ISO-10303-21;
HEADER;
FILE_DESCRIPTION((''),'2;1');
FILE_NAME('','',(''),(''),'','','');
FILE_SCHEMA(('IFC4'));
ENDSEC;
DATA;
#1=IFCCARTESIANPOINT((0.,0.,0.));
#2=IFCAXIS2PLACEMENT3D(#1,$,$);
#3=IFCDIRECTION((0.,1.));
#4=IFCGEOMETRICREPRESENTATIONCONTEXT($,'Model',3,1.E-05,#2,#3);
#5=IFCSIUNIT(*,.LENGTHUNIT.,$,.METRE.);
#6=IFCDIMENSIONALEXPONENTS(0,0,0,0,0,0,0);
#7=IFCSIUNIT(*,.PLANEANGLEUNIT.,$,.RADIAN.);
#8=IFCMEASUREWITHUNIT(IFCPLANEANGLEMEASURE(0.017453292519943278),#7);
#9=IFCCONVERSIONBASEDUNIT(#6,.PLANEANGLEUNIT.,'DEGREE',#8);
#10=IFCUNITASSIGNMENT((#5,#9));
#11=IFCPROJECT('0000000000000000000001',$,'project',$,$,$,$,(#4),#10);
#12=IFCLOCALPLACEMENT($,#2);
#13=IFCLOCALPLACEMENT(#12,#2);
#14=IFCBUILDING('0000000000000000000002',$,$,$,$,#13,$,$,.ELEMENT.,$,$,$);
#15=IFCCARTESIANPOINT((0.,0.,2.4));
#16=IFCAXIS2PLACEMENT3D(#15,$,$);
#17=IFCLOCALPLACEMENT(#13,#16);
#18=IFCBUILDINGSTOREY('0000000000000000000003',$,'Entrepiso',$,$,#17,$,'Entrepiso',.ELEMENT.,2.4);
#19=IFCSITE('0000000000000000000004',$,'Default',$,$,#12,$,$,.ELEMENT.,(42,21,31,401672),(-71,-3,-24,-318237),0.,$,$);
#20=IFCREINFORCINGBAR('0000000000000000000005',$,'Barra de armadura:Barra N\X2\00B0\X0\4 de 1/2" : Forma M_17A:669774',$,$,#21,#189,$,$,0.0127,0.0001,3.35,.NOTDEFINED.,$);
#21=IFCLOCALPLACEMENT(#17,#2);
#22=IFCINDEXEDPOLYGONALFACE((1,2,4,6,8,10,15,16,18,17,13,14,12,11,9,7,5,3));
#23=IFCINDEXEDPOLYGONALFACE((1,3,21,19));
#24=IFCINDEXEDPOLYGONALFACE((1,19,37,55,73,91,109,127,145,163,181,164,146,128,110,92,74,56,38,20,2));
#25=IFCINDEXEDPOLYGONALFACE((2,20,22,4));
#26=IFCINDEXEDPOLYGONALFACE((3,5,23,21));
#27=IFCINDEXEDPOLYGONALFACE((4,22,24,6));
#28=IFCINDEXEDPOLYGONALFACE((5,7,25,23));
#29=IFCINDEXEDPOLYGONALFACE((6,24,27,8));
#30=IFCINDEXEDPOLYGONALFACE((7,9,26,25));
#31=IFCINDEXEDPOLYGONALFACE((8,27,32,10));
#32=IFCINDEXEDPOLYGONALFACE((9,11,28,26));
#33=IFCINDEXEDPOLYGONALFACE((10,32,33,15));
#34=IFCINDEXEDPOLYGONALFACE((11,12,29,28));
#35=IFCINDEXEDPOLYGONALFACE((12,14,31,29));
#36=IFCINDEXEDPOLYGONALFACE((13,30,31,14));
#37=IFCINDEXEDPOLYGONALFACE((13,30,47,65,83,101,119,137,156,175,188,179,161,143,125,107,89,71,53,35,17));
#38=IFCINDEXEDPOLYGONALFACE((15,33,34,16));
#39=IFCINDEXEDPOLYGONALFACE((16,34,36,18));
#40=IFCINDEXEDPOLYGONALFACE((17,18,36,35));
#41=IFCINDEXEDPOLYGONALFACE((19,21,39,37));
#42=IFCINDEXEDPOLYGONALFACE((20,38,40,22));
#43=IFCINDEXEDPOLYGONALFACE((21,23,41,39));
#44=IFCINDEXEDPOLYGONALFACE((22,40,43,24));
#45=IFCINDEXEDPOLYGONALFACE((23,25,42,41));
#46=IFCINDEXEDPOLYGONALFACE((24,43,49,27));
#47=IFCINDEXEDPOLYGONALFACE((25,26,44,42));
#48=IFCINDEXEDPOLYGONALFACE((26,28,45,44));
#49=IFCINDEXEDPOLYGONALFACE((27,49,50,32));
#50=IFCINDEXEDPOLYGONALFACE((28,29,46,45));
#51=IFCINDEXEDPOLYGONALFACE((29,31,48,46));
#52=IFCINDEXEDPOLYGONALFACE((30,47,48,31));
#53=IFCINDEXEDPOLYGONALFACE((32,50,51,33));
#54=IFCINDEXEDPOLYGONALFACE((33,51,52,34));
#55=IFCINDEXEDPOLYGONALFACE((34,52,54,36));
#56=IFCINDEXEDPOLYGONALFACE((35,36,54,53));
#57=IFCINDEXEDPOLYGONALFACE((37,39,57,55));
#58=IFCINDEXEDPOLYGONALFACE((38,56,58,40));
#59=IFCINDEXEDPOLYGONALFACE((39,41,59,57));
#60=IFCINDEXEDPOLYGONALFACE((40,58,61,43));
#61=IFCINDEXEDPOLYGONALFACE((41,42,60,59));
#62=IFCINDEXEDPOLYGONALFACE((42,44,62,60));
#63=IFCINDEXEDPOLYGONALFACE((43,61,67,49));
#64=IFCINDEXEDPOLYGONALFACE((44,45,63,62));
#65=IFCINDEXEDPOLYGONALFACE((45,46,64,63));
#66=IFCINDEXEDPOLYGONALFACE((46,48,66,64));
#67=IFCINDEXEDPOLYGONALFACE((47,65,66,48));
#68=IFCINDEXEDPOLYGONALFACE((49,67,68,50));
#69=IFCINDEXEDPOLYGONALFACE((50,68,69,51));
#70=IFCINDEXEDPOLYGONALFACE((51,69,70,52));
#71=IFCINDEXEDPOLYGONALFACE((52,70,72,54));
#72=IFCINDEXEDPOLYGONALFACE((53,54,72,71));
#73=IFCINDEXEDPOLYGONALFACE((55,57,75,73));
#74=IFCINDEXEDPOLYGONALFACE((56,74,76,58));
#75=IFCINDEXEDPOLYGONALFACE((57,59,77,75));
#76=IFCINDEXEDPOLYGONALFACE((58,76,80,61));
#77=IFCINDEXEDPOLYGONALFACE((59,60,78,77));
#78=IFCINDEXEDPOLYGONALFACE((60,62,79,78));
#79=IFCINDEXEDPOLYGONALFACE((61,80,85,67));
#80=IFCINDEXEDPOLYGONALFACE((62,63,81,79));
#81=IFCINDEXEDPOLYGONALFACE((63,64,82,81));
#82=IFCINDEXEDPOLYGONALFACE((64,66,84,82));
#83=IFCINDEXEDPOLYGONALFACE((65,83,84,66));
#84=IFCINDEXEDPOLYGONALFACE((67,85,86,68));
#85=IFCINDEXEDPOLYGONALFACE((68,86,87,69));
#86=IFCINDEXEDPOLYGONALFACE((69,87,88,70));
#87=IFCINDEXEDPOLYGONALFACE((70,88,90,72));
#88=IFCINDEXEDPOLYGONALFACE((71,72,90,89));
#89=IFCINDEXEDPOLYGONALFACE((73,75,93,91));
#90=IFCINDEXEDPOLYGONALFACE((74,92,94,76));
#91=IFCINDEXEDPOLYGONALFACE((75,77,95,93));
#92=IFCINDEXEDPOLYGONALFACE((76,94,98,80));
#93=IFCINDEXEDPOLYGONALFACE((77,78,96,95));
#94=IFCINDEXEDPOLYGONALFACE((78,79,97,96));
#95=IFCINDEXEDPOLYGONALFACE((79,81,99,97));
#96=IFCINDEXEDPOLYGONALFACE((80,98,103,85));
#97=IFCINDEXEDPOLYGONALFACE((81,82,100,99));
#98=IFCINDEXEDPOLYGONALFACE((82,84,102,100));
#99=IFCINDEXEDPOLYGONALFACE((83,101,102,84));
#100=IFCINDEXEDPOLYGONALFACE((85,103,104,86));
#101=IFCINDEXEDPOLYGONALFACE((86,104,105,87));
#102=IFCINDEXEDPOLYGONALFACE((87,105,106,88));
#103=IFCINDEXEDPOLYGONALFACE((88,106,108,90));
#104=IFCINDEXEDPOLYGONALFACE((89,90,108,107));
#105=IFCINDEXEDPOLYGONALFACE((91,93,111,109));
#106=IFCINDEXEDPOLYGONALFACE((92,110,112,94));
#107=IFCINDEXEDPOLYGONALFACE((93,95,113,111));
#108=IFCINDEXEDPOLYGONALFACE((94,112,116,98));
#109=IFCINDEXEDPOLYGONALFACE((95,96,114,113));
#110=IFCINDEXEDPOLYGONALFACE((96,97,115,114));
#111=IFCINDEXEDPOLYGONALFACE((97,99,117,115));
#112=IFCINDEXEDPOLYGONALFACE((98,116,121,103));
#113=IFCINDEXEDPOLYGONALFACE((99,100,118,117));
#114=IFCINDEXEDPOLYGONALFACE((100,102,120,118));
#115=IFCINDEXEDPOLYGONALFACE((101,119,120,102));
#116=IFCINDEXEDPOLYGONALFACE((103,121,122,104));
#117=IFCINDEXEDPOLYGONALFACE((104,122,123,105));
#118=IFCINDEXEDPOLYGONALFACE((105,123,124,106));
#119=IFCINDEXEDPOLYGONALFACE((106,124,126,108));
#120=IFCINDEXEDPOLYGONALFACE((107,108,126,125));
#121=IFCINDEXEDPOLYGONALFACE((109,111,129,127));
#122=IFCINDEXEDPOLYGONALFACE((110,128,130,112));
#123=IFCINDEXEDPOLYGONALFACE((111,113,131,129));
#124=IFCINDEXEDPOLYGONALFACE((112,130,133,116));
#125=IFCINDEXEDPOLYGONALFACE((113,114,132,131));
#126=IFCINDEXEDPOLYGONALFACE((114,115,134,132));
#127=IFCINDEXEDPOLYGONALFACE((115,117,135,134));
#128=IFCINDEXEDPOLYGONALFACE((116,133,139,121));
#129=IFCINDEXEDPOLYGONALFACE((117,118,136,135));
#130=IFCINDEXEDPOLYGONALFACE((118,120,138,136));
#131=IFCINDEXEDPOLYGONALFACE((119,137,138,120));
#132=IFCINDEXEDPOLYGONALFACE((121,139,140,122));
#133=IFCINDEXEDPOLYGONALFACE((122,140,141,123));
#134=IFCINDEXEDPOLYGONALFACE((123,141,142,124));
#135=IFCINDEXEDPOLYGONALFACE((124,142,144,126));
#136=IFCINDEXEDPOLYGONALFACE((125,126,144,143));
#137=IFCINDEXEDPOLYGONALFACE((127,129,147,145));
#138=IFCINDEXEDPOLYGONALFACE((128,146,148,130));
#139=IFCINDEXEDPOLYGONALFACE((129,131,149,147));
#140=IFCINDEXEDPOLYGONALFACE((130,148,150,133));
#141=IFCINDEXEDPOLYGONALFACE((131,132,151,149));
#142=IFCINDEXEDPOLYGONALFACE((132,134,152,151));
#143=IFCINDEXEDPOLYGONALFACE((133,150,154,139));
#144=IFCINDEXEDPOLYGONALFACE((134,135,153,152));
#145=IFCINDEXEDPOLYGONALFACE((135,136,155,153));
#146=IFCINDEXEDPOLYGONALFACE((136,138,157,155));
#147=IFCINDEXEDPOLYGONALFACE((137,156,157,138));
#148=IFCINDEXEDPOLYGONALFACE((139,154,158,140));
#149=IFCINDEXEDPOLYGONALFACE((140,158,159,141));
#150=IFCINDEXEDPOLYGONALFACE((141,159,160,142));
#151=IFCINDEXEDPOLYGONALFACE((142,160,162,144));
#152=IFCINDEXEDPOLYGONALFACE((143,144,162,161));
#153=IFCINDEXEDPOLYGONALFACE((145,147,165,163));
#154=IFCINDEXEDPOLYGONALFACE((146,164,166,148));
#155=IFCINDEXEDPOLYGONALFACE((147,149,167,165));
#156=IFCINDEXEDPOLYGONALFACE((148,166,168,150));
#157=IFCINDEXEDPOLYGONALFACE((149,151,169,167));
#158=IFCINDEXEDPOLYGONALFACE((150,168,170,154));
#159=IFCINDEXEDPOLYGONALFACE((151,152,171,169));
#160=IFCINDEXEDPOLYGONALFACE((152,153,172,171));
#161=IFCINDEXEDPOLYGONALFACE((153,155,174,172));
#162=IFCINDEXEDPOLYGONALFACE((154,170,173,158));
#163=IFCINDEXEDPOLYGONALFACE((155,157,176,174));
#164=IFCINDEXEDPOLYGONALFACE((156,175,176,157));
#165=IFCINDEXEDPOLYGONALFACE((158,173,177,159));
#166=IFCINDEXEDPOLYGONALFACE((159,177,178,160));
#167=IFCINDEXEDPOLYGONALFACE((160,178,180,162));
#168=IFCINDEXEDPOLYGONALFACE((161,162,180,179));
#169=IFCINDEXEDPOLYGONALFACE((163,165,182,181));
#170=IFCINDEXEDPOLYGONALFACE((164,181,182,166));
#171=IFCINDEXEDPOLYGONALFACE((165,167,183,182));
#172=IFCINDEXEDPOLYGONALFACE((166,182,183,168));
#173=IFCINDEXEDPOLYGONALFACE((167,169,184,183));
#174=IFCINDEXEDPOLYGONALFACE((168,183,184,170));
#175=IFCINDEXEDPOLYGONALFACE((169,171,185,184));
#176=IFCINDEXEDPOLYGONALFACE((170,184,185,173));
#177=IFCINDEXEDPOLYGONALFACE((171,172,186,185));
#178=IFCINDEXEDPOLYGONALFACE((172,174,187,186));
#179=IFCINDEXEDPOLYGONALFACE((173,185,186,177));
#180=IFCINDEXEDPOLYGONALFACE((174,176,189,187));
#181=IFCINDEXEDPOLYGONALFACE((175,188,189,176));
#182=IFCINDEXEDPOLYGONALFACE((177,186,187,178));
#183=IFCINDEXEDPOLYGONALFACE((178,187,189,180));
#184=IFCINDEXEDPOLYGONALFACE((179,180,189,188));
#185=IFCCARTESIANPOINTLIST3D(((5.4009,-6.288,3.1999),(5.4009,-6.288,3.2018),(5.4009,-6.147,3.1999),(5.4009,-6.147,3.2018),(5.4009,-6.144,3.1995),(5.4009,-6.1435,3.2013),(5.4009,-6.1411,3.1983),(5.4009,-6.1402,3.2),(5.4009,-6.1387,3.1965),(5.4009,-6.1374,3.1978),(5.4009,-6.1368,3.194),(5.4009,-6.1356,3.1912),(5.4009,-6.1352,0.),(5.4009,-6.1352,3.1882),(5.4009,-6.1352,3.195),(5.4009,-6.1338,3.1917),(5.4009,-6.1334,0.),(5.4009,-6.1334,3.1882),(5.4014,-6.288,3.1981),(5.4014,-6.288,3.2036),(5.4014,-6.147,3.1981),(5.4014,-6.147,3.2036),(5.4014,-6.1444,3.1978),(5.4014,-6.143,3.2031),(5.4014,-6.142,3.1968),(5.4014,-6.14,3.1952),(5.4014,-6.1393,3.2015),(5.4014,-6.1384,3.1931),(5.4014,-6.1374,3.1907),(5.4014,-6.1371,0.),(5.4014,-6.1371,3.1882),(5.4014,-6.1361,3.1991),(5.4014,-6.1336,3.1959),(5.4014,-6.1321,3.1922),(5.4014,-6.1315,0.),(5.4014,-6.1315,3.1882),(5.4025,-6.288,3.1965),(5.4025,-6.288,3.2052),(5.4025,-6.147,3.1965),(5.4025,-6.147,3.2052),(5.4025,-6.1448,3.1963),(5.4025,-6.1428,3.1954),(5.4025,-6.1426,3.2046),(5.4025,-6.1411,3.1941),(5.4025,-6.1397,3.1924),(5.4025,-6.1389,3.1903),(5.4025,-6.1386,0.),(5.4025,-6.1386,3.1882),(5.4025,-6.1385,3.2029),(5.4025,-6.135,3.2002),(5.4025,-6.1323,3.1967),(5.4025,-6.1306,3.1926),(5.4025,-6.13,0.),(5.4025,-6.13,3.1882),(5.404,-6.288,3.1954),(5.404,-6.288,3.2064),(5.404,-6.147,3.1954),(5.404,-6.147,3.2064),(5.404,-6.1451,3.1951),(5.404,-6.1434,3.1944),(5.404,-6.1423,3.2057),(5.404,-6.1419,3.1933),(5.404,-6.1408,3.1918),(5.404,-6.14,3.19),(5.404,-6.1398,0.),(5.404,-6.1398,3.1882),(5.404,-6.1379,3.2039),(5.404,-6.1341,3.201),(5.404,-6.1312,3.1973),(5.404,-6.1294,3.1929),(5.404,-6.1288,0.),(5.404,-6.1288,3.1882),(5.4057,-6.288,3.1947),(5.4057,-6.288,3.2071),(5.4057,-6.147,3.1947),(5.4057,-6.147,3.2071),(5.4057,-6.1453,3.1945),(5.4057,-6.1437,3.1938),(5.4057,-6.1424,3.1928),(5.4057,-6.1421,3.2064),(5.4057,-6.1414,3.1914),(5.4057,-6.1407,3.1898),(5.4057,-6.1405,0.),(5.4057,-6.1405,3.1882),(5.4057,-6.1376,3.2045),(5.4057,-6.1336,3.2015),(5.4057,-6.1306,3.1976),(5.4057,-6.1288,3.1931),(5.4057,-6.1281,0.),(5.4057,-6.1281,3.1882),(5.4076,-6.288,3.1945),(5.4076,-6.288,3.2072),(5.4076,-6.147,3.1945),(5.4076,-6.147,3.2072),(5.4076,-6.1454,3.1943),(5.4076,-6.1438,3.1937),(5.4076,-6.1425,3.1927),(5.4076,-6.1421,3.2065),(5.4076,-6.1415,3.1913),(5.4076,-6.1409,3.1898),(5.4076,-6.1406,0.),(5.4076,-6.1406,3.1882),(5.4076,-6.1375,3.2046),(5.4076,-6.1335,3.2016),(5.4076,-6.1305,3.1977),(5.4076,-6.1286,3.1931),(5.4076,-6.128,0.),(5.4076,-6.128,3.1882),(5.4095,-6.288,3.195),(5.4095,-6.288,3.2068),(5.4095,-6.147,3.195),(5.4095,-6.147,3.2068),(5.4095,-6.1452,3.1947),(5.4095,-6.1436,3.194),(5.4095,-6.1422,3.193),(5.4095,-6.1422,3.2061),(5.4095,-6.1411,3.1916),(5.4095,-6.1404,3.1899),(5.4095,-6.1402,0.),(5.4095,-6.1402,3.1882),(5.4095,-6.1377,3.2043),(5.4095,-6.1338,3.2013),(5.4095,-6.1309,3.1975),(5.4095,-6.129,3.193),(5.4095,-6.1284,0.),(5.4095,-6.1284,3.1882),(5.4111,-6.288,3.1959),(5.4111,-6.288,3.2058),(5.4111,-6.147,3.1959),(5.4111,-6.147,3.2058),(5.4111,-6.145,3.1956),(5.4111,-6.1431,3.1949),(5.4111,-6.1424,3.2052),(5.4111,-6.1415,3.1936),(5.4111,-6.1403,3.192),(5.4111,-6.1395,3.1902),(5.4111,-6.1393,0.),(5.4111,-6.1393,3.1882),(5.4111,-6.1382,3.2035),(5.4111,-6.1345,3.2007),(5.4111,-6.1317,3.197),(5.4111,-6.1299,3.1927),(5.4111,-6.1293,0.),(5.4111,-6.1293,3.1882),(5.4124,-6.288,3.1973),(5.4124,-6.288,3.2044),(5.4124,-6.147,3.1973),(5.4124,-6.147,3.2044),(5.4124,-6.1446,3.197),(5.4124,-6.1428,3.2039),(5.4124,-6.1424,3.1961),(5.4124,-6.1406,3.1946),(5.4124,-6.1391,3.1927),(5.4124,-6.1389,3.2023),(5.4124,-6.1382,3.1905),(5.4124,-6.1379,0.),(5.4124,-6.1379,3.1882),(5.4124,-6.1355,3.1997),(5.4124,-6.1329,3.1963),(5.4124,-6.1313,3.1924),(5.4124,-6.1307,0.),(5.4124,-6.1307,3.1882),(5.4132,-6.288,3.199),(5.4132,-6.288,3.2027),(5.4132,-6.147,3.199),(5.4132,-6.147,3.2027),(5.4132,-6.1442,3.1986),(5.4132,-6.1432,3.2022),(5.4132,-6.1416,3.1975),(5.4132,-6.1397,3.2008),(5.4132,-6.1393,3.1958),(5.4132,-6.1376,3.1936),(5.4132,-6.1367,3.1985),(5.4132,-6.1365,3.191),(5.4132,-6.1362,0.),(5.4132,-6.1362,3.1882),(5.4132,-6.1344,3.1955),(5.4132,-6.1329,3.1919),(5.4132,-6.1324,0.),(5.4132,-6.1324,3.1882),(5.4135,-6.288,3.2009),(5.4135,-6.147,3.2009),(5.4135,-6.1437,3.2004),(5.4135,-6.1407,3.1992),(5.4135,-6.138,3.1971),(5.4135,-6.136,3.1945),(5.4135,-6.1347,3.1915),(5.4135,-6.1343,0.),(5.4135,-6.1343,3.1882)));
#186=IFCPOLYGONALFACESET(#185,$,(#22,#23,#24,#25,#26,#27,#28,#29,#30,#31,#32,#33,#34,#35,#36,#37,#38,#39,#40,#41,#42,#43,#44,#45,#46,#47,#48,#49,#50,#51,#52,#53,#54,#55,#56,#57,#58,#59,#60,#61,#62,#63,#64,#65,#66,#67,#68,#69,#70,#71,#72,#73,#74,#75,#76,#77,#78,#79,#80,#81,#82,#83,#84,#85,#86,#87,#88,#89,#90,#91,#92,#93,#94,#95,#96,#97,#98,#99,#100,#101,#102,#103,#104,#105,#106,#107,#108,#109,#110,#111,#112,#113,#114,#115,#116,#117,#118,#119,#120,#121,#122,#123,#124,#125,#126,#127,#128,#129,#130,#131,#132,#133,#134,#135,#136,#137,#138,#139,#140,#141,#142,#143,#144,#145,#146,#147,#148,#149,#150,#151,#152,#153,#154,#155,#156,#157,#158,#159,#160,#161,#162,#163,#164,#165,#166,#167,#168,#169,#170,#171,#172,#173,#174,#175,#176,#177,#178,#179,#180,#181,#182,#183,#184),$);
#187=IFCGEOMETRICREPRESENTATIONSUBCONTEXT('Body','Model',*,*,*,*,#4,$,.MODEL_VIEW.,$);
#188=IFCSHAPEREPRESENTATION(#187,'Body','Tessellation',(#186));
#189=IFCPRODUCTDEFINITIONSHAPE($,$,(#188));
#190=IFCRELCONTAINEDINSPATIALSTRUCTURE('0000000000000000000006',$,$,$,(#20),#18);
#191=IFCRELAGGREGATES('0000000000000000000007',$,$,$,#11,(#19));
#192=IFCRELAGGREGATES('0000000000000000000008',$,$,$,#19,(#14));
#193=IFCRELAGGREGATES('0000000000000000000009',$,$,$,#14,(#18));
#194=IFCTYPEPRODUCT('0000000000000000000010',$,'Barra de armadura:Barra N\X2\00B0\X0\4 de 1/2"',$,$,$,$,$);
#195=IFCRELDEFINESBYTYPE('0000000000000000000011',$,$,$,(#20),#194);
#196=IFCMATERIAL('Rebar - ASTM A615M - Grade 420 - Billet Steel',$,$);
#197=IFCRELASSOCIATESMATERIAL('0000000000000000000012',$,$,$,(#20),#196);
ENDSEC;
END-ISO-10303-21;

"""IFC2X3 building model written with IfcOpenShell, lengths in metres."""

from ifc_helpers import new_model, entity, si_unit, converted_unit, direction, frame, origin, place, context, subcontext, project, spatial, material, type_object, element, save


model = new_model("IFC2X3")

# Units and contexts
model_context = context("Model", 3, precision=1e-05, world=origin(), true_north=direction((0.0, 1.0)))
body_context = subcontext(model_context, "Body", "Model", "MODEL_VIEW")
ifc_project = project(units=[si_unit("LENGTHUNIT", "METRE"), converted_unit("PLANEANGLEUNIT", "DEGREE", entity("IfcPlaneAngleMeasure", 0.017453292519943278), si_unit("PLANEANGLEUNIT", "RADIAN"), dimensions=[0, 0, 0, 0, 0, 0, 0])], contexts=[model_context])

# Site, building, storey
site_placement = place(None, origin())
site = spatial("IfcSite", under=ifc_project, at=site_placement, Name="Default", CompositionType="ELEMENT", RefLatitude=(42, 21, 31, 401672), RefLongitude=(-71, -3, -24, -318237), RefElevation=0.0)
building_placement = place(site_placement, origin())
building = spatial("IfcBuilding", under=site, at=building_placement, CompositionType="ELEMENT")
storey_placement = place(building_placement, frame((0.0, 0.0, 2.4)))
storey = spatial("IfcBuildingStorey", under=building, at=storey_placement, Name="Entrepiso", LongName="Entrepiso", CompositionType="ELEMENT", Elevation=2.4)

# Reinforcing bar
ifc_material = material(Name="Rebar - ASTM A615M - Grade 420 - Billet Steel")
type_product_1 = type_object("IfcTypeProduct", Name="Barra de armadura:Barra N°4 de 1/2\"")
reinforcing_bar_1_placement = place(storey_placement, origin())
element("IfcReinforcingBar", 1, at=reinforcing_bar_1_placement, inside=storey, type_object=type_product_1, material=ifc_material, Name="Barra de armadura:Barra N°4 de 1/2\" : Forma M_17A:669774", BarLength=3.35, BarRole="NOTDEFINED", CrossSectionArea=0.0001, NominalDiameter=0.0127, context=body_context, shape_type="AdvancedSweptSolid", body=[
    entity("IfcSweptDiskSolid", entity("IfcCompositeCurve", [entity("IfcCompositeCurveSegment", "CONTINUOUS", True, entity("IfcPolyline", [entity("IfcCartesianPoint", [5.4071, -6.1343, 0.0]), entity("IfcCartesianPoint", [5.4071, -6.1343, 3.1882])])), entity("IfcCompositeCurveSegment", "CONTINUOUS", True, entity("IfcTrimmedCurve", entity("IfcCircle", entity("IfcAxis2Placement3D", entity("IfcCartesianPoint", [5.4071, -6.147, 3.1882]), entity("IfcDirection", [1.0, 0.0, 0.0]), entity("IfcDirection", [0.0, 0.0, 1.0])), 0.0127), [entity("IfcParameterValue", 270.0)], [entity("IfcParameterValue", 360.0)], True, "PARAMETER")), entity("IfcCompositeCurveSegment", "CONTINUOUS", True, entity("IfcPolyline", [entity("IfcCartesianPoint", [5.4071, -6.147, 3.2009]), entity("IfcCartesianPoint", [5.4071, -6.288, 3.2009])]))], False), 0.0063, None, 0.0, 92.0),
])

save(model, "model.ifc")
